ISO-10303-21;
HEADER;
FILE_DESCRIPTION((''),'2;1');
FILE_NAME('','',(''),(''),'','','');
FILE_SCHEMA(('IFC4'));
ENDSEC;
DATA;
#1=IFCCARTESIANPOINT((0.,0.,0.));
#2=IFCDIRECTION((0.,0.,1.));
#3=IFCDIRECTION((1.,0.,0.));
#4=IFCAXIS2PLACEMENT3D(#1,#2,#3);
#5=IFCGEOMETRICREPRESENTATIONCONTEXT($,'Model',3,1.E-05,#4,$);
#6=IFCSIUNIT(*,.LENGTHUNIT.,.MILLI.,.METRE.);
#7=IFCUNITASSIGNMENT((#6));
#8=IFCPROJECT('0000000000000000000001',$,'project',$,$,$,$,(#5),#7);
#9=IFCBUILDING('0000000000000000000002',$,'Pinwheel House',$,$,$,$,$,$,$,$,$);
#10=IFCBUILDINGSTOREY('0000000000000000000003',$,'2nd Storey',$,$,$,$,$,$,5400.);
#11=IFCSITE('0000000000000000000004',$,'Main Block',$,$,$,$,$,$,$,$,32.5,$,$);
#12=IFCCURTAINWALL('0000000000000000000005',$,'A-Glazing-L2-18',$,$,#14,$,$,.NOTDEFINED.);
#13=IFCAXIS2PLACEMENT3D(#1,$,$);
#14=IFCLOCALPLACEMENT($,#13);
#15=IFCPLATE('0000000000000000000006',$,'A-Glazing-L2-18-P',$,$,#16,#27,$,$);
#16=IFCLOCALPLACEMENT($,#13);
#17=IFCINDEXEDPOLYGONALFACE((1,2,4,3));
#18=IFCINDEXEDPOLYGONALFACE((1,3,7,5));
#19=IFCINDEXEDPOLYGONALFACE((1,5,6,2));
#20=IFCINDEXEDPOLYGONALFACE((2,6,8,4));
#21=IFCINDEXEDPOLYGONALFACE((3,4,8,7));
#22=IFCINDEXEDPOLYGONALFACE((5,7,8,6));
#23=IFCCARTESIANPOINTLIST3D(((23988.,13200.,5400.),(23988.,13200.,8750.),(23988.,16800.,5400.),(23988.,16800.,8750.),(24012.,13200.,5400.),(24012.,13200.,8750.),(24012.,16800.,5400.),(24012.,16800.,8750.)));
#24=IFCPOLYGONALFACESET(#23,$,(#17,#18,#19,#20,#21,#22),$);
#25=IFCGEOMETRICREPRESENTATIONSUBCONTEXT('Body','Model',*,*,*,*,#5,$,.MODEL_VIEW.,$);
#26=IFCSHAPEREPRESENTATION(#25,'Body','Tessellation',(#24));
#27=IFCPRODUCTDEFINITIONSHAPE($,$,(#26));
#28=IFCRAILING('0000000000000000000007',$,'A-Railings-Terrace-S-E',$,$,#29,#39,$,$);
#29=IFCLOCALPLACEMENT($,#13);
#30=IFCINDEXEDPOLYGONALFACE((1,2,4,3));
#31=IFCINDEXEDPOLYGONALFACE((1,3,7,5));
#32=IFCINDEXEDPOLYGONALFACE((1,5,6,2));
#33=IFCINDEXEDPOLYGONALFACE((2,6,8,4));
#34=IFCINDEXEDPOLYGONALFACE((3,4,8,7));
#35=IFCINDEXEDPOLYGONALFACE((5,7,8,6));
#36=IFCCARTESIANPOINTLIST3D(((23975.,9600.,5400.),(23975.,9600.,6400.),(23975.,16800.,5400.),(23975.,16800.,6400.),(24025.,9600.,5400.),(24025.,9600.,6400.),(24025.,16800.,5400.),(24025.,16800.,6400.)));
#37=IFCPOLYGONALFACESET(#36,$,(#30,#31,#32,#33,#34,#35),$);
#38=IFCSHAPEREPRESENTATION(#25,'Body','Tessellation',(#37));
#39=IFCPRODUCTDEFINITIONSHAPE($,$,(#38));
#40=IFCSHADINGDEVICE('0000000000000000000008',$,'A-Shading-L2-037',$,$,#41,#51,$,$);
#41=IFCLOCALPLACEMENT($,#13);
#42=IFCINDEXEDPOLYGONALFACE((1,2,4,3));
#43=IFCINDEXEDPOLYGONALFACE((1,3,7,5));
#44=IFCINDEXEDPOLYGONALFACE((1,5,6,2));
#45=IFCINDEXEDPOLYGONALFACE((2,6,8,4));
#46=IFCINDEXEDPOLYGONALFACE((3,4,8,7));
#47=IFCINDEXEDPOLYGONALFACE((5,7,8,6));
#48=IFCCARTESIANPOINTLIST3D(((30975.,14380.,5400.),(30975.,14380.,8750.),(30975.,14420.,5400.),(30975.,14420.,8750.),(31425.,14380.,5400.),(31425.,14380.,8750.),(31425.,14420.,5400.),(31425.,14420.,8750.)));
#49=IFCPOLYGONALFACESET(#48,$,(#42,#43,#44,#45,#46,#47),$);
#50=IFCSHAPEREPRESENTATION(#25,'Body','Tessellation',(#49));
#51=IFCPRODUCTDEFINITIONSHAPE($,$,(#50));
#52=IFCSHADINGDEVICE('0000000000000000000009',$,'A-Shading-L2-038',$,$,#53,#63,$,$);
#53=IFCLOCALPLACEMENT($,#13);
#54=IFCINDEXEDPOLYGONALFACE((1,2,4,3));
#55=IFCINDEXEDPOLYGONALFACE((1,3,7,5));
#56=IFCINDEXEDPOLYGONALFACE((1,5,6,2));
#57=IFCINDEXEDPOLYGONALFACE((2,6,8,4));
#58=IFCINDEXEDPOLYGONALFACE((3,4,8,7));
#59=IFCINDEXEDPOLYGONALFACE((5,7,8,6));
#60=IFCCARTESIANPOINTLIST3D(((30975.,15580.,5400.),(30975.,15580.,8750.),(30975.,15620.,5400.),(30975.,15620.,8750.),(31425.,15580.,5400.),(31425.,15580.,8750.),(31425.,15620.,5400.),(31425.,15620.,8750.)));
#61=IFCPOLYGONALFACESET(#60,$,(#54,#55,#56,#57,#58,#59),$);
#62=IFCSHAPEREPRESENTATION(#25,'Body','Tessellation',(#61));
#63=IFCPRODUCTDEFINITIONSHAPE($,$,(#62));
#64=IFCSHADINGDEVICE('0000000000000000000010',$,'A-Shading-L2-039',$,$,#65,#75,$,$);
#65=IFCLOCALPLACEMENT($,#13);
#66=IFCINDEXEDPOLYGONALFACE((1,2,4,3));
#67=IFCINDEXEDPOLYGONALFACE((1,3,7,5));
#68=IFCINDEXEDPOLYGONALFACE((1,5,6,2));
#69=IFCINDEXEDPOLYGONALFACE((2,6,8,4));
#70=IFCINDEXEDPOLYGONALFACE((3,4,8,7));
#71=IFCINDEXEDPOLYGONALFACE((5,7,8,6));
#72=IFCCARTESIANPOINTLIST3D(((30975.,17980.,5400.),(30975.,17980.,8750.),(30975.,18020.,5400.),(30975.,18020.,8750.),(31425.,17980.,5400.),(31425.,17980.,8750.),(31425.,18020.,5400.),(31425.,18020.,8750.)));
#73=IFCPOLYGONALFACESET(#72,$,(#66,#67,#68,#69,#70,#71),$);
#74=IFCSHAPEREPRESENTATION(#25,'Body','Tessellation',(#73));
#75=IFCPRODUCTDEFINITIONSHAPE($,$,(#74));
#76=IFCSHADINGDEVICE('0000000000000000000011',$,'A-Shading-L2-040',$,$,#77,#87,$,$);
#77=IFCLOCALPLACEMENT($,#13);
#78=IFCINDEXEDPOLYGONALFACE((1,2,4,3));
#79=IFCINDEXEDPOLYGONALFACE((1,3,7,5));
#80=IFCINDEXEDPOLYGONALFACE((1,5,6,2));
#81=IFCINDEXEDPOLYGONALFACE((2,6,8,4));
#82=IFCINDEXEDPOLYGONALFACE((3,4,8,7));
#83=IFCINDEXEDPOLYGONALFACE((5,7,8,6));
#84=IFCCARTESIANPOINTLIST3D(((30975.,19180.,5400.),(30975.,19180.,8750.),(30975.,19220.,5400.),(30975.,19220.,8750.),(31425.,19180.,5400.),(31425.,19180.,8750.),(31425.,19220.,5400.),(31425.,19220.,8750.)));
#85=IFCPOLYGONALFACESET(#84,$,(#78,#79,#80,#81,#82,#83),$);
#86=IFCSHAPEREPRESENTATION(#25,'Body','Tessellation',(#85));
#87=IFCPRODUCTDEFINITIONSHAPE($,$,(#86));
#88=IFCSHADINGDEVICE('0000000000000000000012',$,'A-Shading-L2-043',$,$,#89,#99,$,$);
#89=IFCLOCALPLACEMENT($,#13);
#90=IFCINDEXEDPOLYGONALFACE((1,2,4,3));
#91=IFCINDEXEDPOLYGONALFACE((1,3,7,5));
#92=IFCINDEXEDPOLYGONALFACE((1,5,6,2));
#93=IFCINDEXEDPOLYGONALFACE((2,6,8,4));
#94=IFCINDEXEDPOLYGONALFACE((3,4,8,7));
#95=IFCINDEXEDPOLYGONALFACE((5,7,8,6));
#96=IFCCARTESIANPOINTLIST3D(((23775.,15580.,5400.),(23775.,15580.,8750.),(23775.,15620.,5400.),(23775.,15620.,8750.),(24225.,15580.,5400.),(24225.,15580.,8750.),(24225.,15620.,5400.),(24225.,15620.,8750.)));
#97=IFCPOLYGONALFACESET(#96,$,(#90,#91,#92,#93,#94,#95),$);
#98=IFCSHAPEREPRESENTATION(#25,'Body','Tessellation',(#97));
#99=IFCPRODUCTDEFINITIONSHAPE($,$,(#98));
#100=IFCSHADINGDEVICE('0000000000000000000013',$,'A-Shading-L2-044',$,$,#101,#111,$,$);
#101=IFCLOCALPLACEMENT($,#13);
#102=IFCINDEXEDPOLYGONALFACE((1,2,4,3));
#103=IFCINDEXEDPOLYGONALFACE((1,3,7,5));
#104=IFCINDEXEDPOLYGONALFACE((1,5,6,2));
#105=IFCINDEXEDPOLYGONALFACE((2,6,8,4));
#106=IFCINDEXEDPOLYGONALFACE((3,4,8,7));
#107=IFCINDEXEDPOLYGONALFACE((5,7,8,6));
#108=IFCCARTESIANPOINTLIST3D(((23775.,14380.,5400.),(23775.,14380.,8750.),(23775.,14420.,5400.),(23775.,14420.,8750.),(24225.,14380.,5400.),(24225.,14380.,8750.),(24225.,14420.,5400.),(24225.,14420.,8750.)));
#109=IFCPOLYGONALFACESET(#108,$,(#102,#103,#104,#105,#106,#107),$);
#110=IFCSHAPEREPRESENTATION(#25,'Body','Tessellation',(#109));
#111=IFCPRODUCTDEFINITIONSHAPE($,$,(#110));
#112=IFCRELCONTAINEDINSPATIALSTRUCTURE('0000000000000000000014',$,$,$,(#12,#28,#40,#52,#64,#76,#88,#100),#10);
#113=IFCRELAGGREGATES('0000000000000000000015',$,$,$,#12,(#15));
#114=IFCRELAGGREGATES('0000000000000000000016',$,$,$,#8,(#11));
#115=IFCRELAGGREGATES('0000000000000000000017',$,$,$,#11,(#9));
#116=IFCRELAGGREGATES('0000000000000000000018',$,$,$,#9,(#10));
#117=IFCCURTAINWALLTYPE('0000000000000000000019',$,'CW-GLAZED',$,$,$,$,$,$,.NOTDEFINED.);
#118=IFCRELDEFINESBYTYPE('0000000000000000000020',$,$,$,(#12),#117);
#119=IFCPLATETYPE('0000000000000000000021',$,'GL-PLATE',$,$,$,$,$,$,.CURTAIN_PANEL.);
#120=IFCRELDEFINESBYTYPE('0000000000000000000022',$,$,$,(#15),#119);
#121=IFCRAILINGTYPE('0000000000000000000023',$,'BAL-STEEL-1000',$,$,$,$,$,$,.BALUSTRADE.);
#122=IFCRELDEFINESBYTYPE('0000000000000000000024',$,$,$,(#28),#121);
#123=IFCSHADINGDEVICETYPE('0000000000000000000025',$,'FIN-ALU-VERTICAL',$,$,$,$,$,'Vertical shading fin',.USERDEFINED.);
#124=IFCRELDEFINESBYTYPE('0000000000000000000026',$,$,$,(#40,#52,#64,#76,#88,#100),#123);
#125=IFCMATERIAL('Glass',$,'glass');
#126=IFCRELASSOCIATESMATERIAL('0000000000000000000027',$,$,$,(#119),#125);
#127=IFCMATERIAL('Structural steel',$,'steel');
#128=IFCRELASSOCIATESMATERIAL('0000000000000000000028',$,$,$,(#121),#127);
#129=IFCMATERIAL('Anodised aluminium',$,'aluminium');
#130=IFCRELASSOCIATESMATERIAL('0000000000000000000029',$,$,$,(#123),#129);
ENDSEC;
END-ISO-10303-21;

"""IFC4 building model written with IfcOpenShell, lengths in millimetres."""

from ifc_helpers import new_model, si_unit, frame, origin_with_axes, place, context, subcontext, project, spatial, indexed_curve, outline, extrude, material, type_object, element, aggregate, save


model = new_model("IFC4")

# Units and contexts
model_context = context("Model", 3, precision=1e-05, world=origin_with_axes())
body_context = subcontext(model_context, "Body", "Model", "MODEL_VIEW")
ifc_project = project(units=[si_unit("LENGTHUNIT", "METRE", prefix="MILLI")], contexts=[model_context])

# Site, building, storey
site = spatial("IfcSite", under=ifc_project, Name="Main Block", RefElevation=32.5)
building = spatial("IfcBuilding", under=site, Name="Pinwheel House")
storey = spatial("IfcBuildingStorey", under=building, Name="2nd Storey", Elevation=5400.0)

# Shared definitions
ifc_material_1 = material(Name="Structural steel", Category="steel")

# Shared definitions
ifc_material_2 = material(Name="Anodised aluminium", Category="aluminium")

# Curtain wall, plate
curtain_wall_type = type_object("IfcCurtainWallType", Name="CW-GLAZED", PredefinedType="NOTDEFINED")
ifc_material_3 = material(Name="Glass", Category="glass")
plate_type = type_object("IfcPlateType", Name="GL-PLATE", PredefinedType="CURTAIN_PANEL", material=ifc_material_3)
curtain_wall_1 = element("IfcCurtainWall", 1, inside=storey, type_object=curtain_wall_type, Name="A-Glazing-L2-18", PredefinedType="NOTDEFINED")
plate_1_placement = place(None, frame((24000.0, 15000.0, 5400.0), z_axis=(0.0, 0.0, 1.0), x_axis=(0.0, -1.0, 0.0)))
plate_1 = element("IfcPlate", 2, at=plate_1_placement, type_object=plate_type, Name="A-Glazing-L2-18-P", context=body_context, shape_type="SweptSolid", body=[
    extrude(outline(indexed_curve([(-1800.0, -12.0), (1800.0, -12.0), (1800.0, 12.0), (-1800.0, 12.0)])), None, (0.0, 0.0, 1.0), 3350.0),
])
aggregate(curtain_wall_1, [plate_1])

# Railing
railing_type = type_object("IfcRailingType", Name="BAL-STEEL-1000", PredefinedType="BALUSTRADE", material=ifc_material_1)
railing_placement = place(None, frame((24000.0, 13200.0, 5400.0), z_axis=(0.0, 0.0, 1.0), x_axis=(0.0, 1.0, 0.0)))
element("IfcRailing", 3, at=railing_placement, inside=storey, type_object=railing_type, Name="A-Railings-Terrace-S-E", context=body_context, shape_type="SweptSolid", body=[
    extrude(outline(indexed_curve([(-3600.0, -25.0), (3600.0, -25.0), (3600.0, 25.0), (-3600.0, 25.0)])), None, (0.0, 0.0, 1.0), 1000.0),
])

# Shading devices
shading_device_type = type_object("IfcShadingDeviceType", Name="FIN-ALU-VERTICAL", ElementType="Vertical shading fin", PredefinedType="USERDEFINED", material=ifc_material_2)
for number, where, z_axis, x_axis, name in (
    (4, (31200.0, 14400.0, 5400.0), (0.0, 0.0, 1.0), (0.0, 1.0, 0.0), "A-Shading-L2-037"),
    (5, (31200.0, 15600.0, 5400.0), (0.0, 0.0, 1.0), (0.0, 1.0, 0.0), "A-Shading-L2-038"),
    (6, (31200.0, 18000.0, 5400.0), (0.0, 0.0, 1.0), (0.0, 1.0, 0.0), "A-Shading-L2-039"),
    (7, (31200.0, 19200.0, 5400.0), (0.0, 0.0, 1.0), (0.0, 1.0, 0.0), "A-Shading-L2-040"),
    (8, (24000.0, 15600.0, 5400.0), (0.0, 0.0, 1.0), (0.0, -1.0, 0.0), "A-Shading-L2-043"),
    (9, (24000.0, 14400.0, 5400.0), (0.0, 0.0, 1.0), (0.0, -1.0, 0.0), "A-Shading-L2-044"),
):
    element("IfcShadingDevice", number, at=place(None, frame(where, z_axis=z_axis, x_axis=x_axis)), inside=storey, type_object=shading_device_type, Name=name, context=body_context, shape_type="SweptSolid", body=[
        extrude(outline(indexed_curve([(-20.0, -225.0), (20.0, -225.0), (20.0, 225.0), (-20.0, 225.0)])), None, (0.0, 0.0, 1.0), 3350.0),
    ])

save(model, "model.ifc")
